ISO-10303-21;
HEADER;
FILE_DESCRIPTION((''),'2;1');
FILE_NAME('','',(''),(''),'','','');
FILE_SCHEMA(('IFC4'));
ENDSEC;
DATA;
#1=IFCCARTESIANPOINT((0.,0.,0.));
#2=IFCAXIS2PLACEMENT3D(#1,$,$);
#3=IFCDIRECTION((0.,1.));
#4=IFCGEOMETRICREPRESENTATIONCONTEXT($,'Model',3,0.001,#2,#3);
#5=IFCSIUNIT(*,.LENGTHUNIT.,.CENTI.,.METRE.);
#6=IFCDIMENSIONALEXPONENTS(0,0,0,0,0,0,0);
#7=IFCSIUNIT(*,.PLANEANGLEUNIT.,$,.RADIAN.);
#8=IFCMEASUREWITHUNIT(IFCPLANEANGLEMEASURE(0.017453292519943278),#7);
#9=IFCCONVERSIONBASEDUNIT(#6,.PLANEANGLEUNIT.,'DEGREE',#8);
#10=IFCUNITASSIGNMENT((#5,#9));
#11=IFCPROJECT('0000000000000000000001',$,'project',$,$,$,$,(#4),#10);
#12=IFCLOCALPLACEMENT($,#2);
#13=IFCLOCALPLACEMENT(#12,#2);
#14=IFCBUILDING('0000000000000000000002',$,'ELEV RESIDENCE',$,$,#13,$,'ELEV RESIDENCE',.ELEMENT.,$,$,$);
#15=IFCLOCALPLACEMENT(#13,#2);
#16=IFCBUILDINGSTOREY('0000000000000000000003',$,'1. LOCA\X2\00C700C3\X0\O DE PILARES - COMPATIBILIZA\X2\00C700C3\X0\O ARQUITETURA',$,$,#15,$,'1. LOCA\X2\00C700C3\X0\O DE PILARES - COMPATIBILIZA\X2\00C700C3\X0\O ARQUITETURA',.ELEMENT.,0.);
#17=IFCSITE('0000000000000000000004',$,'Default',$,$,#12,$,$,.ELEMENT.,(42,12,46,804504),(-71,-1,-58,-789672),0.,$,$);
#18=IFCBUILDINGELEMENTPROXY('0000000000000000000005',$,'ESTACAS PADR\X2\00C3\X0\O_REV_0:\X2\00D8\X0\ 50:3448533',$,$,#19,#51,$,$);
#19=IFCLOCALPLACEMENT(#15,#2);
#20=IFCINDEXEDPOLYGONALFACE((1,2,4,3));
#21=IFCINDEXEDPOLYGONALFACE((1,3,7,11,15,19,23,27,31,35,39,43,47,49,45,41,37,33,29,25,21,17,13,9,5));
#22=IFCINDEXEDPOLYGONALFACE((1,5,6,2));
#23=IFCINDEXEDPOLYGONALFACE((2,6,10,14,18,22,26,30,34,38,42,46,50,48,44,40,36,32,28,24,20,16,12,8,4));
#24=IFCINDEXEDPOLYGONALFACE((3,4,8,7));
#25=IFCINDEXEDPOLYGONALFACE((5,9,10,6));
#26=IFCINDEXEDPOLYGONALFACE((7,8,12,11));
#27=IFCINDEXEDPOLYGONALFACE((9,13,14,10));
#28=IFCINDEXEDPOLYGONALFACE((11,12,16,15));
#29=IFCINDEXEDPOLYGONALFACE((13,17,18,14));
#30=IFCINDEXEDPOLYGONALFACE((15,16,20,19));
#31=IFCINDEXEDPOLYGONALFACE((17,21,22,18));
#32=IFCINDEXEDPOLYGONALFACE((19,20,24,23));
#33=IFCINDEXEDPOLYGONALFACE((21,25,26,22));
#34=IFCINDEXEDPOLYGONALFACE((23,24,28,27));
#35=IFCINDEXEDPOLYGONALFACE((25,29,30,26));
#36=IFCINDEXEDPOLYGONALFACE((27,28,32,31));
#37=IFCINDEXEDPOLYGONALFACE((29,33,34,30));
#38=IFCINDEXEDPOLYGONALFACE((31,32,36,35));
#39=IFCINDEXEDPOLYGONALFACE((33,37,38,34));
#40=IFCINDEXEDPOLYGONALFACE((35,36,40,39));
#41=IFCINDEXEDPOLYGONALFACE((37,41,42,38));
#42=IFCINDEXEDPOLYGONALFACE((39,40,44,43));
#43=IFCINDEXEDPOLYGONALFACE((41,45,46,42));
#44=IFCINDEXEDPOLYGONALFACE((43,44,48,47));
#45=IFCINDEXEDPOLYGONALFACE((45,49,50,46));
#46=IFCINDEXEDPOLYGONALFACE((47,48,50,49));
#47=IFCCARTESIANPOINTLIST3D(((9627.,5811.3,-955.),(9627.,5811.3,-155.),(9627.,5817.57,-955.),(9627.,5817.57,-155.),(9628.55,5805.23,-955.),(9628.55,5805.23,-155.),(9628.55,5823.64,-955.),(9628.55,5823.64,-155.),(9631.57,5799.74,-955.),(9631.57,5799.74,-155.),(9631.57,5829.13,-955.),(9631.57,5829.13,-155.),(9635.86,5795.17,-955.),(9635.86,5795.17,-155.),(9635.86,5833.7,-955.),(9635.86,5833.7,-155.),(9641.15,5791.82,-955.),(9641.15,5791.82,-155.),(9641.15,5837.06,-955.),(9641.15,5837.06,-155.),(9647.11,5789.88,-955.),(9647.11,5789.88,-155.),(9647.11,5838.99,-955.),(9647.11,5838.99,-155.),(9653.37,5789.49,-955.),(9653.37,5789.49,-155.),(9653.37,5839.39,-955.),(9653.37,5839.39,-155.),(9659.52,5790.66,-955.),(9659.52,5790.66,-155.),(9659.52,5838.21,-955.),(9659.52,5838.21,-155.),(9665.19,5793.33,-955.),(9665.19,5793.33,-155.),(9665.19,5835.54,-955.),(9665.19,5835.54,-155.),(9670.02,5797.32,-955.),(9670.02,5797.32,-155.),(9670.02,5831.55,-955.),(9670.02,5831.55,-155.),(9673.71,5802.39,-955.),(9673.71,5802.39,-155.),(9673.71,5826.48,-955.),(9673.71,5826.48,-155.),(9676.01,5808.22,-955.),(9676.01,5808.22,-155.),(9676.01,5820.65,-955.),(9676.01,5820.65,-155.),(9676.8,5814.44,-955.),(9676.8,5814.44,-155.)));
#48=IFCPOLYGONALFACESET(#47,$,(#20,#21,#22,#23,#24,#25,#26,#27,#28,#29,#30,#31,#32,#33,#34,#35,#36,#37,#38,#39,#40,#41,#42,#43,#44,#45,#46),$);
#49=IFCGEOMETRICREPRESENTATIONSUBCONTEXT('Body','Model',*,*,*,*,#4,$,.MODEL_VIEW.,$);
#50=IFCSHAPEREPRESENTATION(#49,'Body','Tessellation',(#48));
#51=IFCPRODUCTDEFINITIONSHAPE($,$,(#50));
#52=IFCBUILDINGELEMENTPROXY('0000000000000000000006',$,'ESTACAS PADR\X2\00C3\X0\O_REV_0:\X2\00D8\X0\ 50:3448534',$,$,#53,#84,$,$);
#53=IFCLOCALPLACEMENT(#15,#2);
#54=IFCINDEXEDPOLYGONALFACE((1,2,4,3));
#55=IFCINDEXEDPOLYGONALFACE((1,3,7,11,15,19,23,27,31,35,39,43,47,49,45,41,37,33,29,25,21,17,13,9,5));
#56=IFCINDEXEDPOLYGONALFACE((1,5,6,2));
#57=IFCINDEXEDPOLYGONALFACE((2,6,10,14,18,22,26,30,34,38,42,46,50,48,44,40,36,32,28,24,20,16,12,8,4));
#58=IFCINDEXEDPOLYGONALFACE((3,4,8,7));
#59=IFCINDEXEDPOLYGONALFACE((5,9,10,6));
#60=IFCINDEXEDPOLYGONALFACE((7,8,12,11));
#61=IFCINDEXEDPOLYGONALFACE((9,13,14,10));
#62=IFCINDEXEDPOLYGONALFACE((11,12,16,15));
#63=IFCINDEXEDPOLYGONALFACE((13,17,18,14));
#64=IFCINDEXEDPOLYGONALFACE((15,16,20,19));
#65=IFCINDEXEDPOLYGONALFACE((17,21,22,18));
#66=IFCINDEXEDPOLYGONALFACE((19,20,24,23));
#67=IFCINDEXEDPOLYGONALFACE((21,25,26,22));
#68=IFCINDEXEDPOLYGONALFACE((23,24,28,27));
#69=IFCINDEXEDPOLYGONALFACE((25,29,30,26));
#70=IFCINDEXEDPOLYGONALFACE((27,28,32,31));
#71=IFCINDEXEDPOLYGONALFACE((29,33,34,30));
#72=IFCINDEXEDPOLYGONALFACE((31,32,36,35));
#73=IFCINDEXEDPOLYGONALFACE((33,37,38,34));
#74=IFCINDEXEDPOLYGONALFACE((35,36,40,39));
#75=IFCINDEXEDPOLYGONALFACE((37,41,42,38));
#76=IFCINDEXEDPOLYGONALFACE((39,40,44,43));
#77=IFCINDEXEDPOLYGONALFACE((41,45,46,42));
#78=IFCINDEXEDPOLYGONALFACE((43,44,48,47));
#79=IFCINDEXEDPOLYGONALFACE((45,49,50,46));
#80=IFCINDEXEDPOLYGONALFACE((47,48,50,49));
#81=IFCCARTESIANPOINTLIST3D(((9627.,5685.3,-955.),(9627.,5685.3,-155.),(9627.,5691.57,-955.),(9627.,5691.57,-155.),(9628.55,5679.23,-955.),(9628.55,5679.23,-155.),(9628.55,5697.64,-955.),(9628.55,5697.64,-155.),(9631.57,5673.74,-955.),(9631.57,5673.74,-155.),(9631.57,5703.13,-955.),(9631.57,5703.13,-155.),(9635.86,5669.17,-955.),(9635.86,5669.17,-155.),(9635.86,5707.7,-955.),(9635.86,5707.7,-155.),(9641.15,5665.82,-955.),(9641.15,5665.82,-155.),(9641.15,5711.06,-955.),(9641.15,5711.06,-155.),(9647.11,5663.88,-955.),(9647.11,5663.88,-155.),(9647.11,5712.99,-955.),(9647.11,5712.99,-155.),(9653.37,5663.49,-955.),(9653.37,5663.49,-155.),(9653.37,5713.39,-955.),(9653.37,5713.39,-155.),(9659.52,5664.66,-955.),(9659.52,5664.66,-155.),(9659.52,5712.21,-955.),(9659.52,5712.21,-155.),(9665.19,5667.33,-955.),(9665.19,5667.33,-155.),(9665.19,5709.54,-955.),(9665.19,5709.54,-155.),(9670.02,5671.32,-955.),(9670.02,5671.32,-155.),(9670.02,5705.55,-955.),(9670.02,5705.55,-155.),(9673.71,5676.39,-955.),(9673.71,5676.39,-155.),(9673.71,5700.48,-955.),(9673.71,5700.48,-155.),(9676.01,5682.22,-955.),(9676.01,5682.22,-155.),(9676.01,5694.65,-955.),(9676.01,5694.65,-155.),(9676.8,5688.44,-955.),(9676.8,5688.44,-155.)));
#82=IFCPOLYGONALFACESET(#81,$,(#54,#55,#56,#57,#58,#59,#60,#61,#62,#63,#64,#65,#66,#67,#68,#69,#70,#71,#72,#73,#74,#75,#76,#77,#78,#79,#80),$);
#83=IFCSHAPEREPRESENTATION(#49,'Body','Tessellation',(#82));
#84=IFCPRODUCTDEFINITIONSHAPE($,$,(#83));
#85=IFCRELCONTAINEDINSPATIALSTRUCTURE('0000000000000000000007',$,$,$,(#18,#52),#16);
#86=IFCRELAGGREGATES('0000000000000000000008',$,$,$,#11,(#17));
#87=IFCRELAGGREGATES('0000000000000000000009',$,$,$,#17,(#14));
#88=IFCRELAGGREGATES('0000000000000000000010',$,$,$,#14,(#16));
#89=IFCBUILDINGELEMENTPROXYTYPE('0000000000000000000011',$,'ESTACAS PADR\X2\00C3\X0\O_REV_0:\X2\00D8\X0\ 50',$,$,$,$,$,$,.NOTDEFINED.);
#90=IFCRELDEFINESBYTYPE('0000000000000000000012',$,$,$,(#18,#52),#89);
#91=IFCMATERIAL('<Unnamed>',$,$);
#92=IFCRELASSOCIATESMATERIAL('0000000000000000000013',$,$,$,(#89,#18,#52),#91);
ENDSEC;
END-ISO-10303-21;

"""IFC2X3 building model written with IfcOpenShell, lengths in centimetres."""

from ifc_helpers import new_model, entity, si_unit, converted_unit, direction, frame, frame_2d, origin, place, context, subcontext, project, spatial, circle, extrude, source, transform, mapped, material, type_object, type_shapes, element, save


model = new_model("IFC2X3")

# Units and contexts
model_context = context("Model", 3, precision=0.001, world=origin(), true_north=direction((0.0, 1.0)))
body_context = subcontext(model_context, "Body", "Model", "MODEL_VIEW")
ifc_project = project(units=[si_unit("LENGTHUNIT", "METRE", prefix="CENTI"), converted_unit("PLANEANGLEUNIT", "DEGREE", entity("IfcPlaneAngleMeasure", 0.017453292519943278), si_unit("PLANEANGLEUNIT", "RADIAN"), dimensions=[0, 0, 0, 0, 0, 0, 0])], contexts=[model_context])

# Site, building, storey
site_placement = place(None, origin())
site = spatial("IfcSite", under=ifc_project, at=site_placement, Name="Default", CompositionType="ELEMENT", RefLatitude=(42, 12, 46, 804504), RefLongitude=(-71, -1, -58, -789672), RefElevation=0.0)
building_placement = place(site_placement, origin())
building = spatial("IfcBuilding", under=site, at=building_placement, Name="ELEV RESIDENCE", LongName="ELEV RESIDENCE", CompositionType="ELEMENT")
storey_placement = place(building_placement, origin())
storey = spatial("IfcBuildingStorey", under=building, at=storey_placement, Name="1. LOCAÇÃO DE PILARES - COMPATIBILIZAÇÃO ARQUITETURA", LongName="1. LOCAÇÃO DE PILARES - COMPATIBILIZAÇÃO ARQUITETURA", CompositionType="ELEMENT", Elevation=0.0)

# Building element proxies
ifc_material_1 = material(Name="<Unnamed>")
building_element_proxy_type_1 = type_object("IfcBuildingElementProxyType", Name="ESTACAS PADRÃO_REV_0:Ø 50", PredefinedType="NOTDEFINED", material=ifc_material_1)
shared_shape_1 = source(origin(), body_context, "Body", "SweptSolid", [
    extrude(circle(Radius=25.0, at=frame_2d((0.0, 0.0), x_axis=(1.0, 0.0))), frame((0.0, 0.0, -955.0)), (0.0, 0.0, 1.0), 800.0),
])
type_shapes(building_element_proxy_type_1, [shared_shape_1])
for number, where, name in (
    (1, (9651.8, 5814.44, 0.0), "ESTACAS PADRÃO_REV_0:Ø 50:3448533"),
    (2, (9651.8, 5688.44, 0.0), "ESTACAS PADRÃO_REV_0:Ø 50:3448534"),
):
    element("IfcBuildingElementProxy", number, at=place(storey_placement, frame(where)), inside=storey, type_object=building_element_proxy_type_1, material=ifc_material_1, Name=name, context=body_context, shape_type="MappedRepresentation", body=[
        mapped(shared_shape_1, transform((0.0, 0.0, 0.0), scale=1.0)),
    ])

save(model, "model.ifc")
